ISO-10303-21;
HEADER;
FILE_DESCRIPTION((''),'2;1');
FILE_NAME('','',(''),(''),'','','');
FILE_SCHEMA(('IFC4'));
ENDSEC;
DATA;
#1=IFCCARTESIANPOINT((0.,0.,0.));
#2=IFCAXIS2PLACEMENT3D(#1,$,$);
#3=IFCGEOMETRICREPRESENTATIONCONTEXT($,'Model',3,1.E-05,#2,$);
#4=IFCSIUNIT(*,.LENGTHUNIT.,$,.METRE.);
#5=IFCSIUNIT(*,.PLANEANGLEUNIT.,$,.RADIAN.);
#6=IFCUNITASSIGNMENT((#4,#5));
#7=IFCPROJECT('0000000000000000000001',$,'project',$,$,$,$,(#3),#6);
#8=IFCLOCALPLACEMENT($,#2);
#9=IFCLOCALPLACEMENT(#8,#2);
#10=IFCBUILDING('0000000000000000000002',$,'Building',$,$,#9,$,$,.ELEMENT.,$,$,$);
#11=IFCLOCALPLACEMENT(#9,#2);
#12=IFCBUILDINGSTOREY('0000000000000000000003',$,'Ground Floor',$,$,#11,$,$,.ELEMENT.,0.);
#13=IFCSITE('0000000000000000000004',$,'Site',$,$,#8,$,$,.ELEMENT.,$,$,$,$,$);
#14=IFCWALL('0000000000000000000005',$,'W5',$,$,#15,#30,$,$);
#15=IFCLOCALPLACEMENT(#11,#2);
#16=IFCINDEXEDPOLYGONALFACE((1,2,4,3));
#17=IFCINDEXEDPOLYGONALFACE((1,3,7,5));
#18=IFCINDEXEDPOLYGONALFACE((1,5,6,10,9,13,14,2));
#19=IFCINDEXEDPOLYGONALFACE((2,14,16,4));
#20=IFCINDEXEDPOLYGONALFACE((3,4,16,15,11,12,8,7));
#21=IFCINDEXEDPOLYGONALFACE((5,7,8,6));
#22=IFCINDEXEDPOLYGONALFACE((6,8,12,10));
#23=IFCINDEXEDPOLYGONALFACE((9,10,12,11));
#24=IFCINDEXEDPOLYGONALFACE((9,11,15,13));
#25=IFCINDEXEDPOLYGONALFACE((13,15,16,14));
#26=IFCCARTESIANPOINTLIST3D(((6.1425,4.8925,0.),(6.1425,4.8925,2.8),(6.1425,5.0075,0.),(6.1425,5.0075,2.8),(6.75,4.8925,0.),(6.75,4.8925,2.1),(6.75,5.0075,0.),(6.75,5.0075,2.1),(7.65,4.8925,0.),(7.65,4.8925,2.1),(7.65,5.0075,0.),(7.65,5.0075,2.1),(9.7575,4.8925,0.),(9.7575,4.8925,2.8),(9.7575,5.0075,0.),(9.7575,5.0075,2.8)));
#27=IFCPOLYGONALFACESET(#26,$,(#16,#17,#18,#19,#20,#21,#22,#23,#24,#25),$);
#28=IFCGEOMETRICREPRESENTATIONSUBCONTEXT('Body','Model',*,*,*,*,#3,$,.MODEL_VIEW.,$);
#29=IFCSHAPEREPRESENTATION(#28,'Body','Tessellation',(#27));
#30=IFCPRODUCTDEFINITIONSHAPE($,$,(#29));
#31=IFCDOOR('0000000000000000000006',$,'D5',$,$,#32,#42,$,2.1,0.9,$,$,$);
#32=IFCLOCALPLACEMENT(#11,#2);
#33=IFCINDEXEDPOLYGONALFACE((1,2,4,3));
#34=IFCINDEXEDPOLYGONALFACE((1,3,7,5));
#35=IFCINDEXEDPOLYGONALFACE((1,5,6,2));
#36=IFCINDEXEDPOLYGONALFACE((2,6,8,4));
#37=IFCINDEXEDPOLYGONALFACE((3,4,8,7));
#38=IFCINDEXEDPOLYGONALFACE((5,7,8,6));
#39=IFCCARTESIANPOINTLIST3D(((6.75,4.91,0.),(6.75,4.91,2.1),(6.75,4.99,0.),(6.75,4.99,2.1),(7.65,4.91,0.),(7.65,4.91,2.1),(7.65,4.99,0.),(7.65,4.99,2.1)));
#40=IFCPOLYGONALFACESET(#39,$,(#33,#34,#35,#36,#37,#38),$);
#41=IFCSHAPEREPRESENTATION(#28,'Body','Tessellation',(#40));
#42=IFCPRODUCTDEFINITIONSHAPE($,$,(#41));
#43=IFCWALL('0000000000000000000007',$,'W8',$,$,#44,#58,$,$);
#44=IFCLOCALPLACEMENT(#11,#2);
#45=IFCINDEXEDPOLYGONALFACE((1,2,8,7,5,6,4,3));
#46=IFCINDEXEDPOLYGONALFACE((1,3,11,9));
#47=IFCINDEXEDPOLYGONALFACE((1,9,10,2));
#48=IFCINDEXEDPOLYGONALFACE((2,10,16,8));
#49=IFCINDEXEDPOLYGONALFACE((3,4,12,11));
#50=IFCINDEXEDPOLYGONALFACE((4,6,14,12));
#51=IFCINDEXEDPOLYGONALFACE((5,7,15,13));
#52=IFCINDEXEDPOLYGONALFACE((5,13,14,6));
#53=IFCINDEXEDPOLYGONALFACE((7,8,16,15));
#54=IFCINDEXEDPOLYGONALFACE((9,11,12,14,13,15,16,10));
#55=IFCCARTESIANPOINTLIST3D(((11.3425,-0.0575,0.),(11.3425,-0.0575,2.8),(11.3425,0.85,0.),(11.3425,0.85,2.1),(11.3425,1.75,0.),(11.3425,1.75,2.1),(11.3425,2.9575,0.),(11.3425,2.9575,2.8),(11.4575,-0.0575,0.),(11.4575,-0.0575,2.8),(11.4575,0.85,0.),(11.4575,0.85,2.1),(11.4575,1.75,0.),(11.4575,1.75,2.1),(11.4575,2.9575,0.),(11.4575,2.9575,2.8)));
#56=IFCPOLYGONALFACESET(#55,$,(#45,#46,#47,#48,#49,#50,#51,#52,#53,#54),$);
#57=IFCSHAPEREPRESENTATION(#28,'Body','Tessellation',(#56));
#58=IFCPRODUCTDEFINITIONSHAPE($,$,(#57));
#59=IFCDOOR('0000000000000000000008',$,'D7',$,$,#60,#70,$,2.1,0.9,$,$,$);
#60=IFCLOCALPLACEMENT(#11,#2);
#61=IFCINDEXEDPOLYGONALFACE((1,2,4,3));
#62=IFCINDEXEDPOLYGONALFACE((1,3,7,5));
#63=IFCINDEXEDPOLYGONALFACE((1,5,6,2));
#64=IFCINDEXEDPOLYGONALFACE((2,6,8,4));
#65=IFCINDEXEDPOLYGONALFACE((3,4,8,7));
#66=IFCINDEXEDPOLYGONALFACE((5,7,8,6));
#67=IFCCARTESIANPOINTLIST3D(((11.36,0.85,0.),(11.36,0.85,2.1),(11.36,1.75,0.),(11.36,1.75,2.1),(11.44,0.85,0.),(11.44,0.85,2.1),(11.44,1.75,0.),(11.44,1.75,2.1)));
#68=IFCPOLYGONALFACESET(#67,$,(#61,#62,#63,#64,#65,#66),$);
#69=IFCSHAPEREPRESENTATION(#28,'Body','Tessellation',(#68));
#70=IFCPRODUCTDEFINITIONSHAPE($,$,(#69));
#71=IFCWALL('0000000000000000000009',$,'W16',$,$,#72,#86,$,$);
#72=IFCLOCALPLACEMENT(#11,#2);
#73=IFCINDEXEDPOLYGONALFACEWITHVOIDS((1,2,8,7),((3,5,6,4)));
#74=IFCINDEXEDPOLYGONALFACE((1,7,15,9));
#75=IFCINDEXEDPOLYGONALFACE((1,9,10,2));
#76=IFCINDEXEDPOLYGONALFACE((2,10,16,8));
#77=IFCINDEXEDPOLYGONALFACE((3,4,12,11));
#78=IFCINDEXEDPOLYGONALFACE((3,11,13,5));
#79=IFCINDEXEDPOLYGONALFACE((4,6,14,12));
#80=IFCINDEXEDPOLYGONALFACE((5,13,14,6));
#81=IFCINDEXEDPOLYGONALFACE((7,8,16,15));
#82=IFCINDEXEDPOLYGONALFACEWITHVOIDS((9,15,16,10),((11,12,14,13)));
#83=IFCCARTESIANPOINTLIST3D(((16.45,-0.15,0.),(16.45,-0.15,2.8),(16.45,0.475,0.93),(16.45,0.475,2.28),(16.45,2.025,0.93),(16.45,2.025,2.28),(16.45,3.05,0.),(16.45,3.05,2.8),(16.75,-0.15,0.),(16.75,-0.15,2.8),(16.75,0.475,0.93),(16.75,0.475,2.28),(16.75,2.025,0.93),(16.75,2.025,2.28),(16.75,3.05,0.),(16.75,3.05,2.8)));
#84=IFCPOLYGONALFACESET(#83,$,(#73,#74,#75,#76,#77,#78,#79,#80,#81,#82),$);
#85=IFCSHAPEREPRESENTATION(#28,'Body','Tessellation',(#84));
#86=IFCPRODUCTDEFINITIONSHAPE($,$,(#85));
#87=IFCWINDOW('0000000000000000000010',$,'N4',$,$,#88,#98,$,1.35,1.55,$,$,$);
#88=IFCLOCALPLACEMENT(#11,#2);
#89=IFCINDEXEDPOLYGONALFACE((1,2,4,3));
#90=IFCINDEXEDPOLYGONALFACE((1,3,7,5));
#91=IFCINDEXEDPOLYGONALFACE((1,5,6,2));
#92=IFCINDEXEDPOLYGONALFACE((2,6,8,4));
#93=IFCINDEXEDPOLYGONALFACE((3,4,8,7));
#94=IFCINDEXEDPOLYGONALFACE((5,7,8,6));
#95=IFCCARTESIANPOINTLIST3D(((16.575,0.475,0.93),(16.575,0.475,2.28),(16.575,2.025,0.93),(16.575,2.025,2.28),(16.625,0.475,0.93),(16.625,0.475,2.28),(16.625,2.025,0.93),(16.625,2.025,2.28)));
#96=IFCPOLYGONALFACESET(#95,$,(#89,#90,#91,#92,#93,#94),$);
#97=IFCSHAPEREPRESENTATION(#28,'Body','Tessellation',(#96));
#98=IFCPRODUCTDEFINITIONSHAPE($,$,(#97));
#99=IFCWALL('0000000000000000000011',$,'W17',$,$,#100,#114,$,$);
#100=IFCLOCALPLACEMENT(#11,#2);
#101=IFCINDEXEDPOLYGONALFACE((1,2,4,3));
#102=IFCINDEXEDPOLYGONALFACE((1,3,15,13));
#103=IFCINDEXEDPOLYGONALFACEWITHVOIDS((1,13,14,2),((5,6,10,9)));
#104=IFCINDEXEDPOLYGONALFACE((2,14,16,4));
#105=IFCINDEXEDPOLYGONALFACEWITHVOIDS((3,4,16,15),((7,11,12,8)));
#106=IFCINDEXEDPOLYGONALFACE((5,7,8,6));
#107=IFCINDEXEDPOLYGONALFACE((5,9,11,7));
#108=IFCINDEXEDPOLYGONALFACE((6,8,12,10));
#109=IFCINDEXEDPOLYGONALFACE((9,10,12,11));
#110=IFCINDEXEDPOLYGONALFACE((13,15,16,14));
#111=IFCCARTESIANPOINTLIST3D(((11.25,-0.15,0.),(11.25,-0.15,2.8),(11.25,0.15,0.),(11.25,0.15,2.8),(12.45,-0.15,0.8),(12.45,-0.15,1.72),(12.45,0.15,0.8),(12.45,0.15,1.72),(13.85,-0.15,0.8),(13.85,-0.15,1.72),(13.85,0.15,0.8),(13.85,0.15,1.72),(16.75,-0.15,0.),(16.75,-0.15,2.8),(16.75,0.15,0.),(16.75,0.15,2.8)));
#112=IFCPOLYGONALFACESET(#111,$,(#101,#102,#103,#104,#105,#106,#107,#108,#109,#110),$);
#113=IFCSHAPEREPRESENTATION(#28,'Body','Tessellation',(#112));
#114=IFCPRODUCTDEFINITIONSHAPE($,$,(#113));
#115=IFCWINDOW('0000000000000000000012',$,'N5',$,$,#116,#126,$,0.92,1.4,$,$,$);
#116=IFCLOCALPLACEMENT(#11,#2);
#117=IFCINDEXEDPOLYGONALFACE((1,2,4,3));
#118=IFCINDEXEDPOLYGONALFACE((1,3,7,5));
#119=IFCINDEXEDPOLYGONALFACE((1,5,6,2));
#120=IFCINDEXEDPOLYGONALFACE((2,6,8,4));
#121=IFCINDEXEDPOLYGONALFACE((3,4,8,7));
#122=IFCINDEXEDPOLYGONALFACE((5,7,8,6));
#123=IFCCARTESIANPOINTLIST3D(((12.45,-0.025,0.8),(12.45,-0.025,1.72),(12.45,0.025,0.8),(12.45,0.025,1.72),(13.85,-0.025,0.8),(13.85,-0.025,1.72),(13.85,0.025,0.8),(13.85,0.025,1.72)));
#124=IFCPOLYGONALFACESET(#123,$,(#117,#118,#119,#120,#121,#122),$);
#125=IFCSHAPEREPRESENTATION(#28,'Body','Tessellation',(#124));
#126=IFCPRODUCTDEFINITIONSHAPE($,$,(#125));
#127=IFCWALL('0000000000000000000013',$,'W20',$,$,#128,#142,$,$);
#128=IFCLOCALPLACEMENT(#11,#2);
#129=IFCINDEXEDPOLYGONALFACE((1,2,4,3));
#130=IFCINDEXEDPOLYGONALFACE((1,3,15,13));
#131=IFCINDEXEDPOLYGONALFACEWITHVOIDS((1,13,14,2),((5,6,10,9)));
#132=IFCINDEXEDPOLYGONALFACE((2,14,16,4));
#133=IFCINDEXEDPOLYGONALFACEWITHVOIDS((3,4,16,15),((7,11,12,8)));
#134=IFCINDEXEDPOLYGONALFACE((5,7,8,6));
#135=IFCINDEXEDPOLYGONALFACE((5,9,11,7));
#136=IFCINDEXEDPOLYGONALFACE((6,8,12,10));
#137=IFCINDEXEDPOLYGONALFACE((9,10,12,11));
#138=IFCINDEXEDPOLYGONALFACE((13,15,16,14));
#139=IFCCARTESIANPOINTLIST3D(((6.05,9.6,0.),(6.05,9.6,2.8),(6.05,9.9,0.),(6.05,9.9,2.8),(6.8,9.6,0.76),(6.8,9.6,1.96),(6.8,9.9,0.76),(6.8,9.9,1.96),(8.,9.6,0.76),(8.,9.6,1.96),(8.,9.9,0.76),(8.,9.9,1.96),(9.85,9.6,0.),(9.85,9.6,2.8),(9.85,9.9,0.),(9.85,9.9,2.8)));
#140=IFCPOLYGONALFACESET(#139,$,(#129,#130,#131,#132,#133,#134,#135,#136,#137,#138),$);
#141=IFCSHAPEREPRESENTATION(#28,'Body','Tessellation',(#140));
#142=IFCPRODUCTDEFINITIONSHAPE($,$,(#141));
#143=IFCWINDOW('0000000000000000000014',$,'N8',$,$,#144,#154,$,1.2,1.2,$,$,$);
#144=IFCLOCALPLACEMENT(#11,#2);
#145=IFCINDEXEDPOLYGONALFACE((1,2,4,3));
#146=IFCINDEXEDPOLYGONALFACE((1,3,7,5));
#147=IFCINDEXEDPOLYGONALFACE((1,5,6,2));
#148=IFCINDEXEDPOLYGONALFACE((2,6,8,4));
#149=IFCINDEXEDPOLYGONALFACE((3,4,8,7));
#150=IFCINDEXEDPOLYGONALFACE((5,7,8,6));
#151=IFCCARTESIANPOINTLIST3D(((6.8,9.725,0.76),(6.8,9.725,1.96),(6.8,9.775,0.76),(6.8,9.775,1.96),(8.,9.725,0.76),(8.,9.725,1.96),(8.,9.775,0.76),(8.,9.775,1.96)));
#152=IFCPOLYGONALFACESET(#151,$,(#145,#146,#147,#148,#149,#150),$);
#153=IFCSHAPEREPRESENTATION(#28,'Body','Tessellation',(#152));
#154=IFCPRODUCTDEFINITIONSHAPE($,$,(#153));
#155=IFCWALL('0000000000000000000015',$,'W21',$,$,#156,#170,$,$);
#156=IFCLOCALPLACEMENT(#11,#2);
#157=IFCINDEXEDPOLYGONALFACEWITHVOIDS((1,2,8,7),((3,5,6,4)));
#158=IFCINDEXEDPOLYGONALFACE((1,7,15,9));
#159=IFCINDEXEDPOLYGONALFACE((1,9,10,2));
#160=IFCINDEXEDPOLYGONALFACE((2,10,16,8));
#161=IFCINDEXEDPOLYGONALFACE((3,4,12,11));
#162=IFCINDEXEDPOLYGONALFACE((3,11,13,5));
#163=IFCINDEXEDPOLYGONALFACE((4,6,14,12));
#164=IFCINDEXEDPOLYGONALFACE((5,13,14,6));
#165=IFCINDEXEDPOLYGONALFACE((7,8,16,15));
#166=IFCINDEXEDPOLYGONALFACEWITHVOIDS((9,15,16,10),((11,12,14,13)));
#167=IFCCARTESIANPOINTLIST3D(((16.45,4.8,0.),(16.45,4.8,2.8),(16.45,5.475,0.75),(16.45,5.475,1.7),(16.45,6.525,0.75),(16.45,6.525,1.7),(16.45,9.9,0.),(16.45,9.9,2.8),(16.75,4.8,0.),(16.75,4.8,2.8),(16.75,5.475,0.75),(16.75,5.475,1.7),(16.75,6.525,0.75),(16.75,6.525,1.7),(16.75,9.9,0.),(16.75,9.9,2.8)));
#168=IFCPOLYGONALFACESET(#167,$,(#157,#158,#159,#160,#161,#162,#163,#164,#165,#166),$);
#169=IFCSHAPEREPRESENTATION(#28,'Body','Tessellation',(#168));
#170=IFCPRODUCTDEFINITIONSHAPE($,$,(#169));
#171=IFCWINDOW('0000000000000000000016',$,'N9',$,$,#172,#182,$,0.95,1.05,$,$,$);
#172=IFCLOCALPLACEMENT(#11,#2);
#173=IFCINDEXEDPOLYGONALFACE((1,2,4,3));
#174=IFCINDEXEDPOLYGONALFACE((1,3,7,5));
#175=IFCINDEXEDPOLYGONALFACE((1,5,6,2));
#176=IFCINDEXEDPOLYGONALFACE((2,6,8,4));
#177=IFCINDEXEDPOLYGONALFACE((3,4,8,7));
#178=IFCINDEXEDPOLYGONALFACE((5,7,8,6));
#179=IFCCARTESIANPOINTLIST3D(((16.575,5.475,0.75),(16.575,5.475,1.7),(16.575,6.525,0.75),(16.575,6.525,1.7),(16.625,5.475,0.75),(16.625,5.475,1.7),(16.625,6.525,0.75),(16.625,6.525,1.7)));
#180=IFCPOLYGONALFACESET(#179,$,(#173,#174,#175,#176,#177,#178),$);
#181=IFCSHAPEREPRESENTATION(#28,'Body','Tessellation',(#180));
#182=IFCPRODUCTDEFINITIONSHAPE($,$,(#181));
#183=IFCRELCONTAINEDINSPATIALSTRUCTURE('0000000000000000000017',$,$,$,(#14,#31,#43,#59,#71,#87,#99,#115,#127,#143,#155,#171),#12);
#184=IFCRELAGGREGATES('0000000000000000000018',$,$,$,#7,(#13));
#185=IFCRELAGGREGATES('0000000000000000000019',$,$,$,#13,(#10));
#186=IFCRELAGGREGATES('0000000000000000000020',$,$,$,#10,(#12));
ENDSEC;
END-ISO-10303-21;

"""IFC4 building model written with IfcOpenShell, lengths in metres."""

from ifc_helpers import new_model, si_unit, frame, frame_2d, origin, origin_2d, place, context, subcontext, project, spatial, rectangle, extrude, element, fill, save


model = new_model("IFC4")

# Units and contexts
model_context = context("Model", 3, precision=1e-05, world=origin())
body_context = subcontext(model_context, "Body", "Model", "MODEL_VIEW")
ifc_project = project(units=[si_unit("LENGTHUNIT", "METRE"), si_unit("PLANEANGLEUNIT", "RADIAN")], contexts=[model_context])

# Site, building, storey
site_placement = place(None, origin())
site = spatial("IfcSite", under=ifc_project, at=site_placement, Name="Site", CompositionType="ELEMENT")
building_placement = place(site_placement, origin())
building = spatial("IfcBuilding", under=site, at=building_placement, Name="Building", CompositionType="ELEMENT")
storey_placement = place(building_placement, origin())
storey = spatial("IfcBuildingStorey", under=building, at=storey_placement, Name="Ground Floor", CompositionType="ELEMENT", Elevation=0.0)

# Walls, openings, doors
wall_1_placement = place(storey_placement, frame((6.2, 4.95, 0.0), x_axis=(1.0, 0.0, 0.0)))
wall_1 = element("IfcWall", 1, at=wall_1_placement, inside=storey, Name="W5", context=body_context, shape_type="SweptSolid", body=[
    extrude(rectangle(XDim=3.615, YDim=0.115, at=frame_2d((1.75, 0.0))), origin(), (0.0, 0.0, 1.0), 2.8),
])
opening_1_placement = place(wall_1_placement, frame((1.0, 0.0, 0.0)))
opening_1 = element("IfcOpeningElement", 2, at=opening_1_placement, cuts=wall_1, context=body_context, shape_type="SweptSolid", body=[
    extrude(rectangle(XDim=0.9, YDim=0.215, at=origin_2d()), origin(), (0.0, 0.0, 1.0), 2.1),
])
door_1_placement = place(opening_1_placement, origin())
door_1 = element("IfcDoor", 3, at=door_1_placement, inside=storey, Name="D5", OverallHeight=2.1, OverallWidth=0.9, context=body_context, shape_type="SweptSolid", body=[
    extrude(rectangle(XDim=0.9, YDim=0.08, at=origin_2d()), origin(), (0.0, 0.0, 1.0), 2.1),
])
fill(opening_1, door_1)
wall_2_placement = place(storey_placement, frame((11.4, 0.0, 0.0), x_axis=(0.0, 1.0, 0.0)))
wall_2 = element("IfcWall", 4, at=wall_2_placement, inside=storey, Name="W8", context=body_context, shape_type="SweptSolid", body=[
    extrude(rectangle(XDim=3.015, YDim=0.115, at=frame_2d((1.45, 0.0))), origin(), (0.0, 0.0, 1.0), 2.8),
])
opening_2_placement = place(wall_2_placement, frame((1.3, 0.0, 0.0)))
opening_2 = element("IfcOpeningElement", 5, at=opening_2_placement, cuts=wall_2, context=body_context, shape_type="SweptSolid", body=[
    extrude(rectangle(XDim=0.9, YDim=0.215, at=origin_2d()), origin(), (0.0, 0.0, 1.0), 2.1),
])
door_2_placement = place(opening_2_placement, origin())
door_2 = element("IfcDoor", 6, at=door_2_placement, inside=storey, Name="D7", OverallHeight=2.1, OverallWidth=0.9, context=body_context, shape_type="SweptSolid", body=[
    extrude(rectangle(XDim=0.9, YDim=0.08, at=origin_2d()), origin(), (0.0, 0.0, 1.0), 2.1),
])
fill(opening_2, door_2)

# Walls, openings, windows
wall_3_placement = place(storey_placement, frame((16.6, 0.0, 0.0), x_axis=(0.0, 1.0, 0.0)))
wall_3 = element("IfcWall", 7, at=wall_3_placement, inside=storey, Name="W16", context=body_context, shape_type="SweptSolid", body=[
    extrude(rectangle(XDim=3.2, YDim=0.3, at=frame_2d((1.45, 0.0))), origin(), (0.0, 0.0, 1.0), 2.8),
])
opening_3_placement = place(wall_3_placement, frame((1.25, 0.0, 0.93)))
opening_3 = element("IfcOpeningElement", 8, at=opening_3_placement, cuts=wall_3, context=body_context, shape_type="SweptSolid", body=[
    extrude(rectangle(XDim=1.55, YDim=0.4, at=origin_2d()), origin(), (0.0, 0.0, 1.0), 1.35),
])
window_1_placement = place(opening_3_placement, origin())
window_1 = element("IfcWindow", 9, at=window_1_placement, inside=storey, Name="N4", OverallHeight=1.35, OverallWidth=1.55, context=body_context, shape_type="SweptSolid", body=[
    extrude(rectangle(XDim=1.55, YDim=0.05, at=origin_2d()), origin(), (0.0, 0.0, 1.0), 1.35),
])
fill(opening_3, window_1)
wall_4_placement = place(storey_placement, frame((11.4, 0.0, 0.0), x_axis=(1.0, 0.0, 0.0)))
wall_4 = element("IfcWall", 10, at=wall_4_placement, inside=storey, Name="W17", context=body_context, shape_type="SweptSolid", body=[
    extrude(rectangle(XDim=5.5, YDim=0.3, at=frame_2d((2.6, 0.0))), origin(), (0.0, 0.0, 1.0), 2.8),
])
opening_4_placement = place(wall_4_placement, frame((1.75, 0.0, 0.8)))
opening_4 = element("IfcOpeningElement", 11, at=opening_4_placement, cuts=wall_4, context=body_context, shape_type="SweptSolid", body=[
    extrude(rectangle(XDim=1.4, YDim=0.4, at=origin_2d()), origin(), (0.0, 0.0, 1.0), 0.92),
])
window_2_placement = place(opening_4_placement, origin())
window_2 = element("IfcWindow", 12, at=window_2_placement, inside=storey, Name="N5", OverallHeight=0.92, OverallWidth=1.4, context=body_context, shape_type="SweptSolid", body=[
    extrude(rectangle(XDim=1.4, YDim=0.05, at=origin_2d()), origin(), (0.0, 0.0, 1.0), 0.92),
])
fill(opening_4, window_2)
wall_5_placement = place(storey_placement, frame((6.2, 9.75, 0.0), x_axis=(1.0, 0.0, 0.0)))
wall_5 = element("IfcWall", 13, at=wall_5_placement, inside=storey, Name="W20", context=body_context, shape_type="SweptSolid", body=[
    extrude(rectangle(XDim=3.8, YDim=0.3, at=frame_2d((1.75, 0.0))), origin(), (0.0, 0.0, 1.0), 2.8),
])
opening_5_placement = place(wall_5_placement, frame((1.2, 0.0, 0.76)))
opening_5 = element("IfcOpeningElement", 14, at=opening_5_placement, cuts=wall_5, context=body_context, shape_type="SweptSolid", body=[
    extrude(rectangle(XDim=1.2, YDim=0.4, at=origin_2d()), origin(), (0.0, 0.0, 1.0), 1.2),
])
window_3_placement = place(opening_5_placement, origin())
window_3 = element("IfcWindow", 15, at=window_3_placement, inside=storey, Name="N8", OverallHeight=1.2, OverallWidth=1.2, context=body_context, shape_type="SweptSolid", body=[
    extrude(rectangle(XDim=1.2, YDim=0.05, at=origin_2d()), origin(), (0.0, 0.0, 1.0), 1.2),
])
fill(opening_5, window_3)
wall_6_placement = place(storey_placement, frame((16.6, 4.95, 0.0), x_axis=(0.0, 1.0, 0.0)))
wall_6 = element("IfcWall", 16, at=wall_6_placement, inside=storey, Name="W21", context=body_context, shape_type="SweptSolid", body=[
    extrude(rectangle(XDim=5.1, YDim=0.3, at=frame_2d((2.4, 0.0))), origin(), (0.0, 0.0, 1.0), 2.8),
])
opening_6_placement = place(wall_6_placement, frame((1.05, 0.0, 0.75)))
opening_6 = element("IfcOpeningElement", 17, at=opening_6_placement, cuts=wall_6, context=body_context, shape_type="SweptSolid", body=[
    extrude(rectangle(XDim=1.05, YDim=0.4, at=origin_2d()), origin(), (0.0, 0.0, 1.0), 0.95),
])
window_4_placement = place(opening_6_placement, origin())
window_4 = element("IfcWindow", 18, at=window_4_placement, inside=storey, Name="N9", OverallHeight=0.95, OverallWidth=1.05, context=body_context, shape_type="SweptSolid", body=[
    extrude(rectangle(XDim=1.05, YDim=0.05, at=origin_2d()), origin(), (0.0, 0.0, 1.0), 0.95),
])
fill(opening_6, window_4)

save(model, "model.ifc")
